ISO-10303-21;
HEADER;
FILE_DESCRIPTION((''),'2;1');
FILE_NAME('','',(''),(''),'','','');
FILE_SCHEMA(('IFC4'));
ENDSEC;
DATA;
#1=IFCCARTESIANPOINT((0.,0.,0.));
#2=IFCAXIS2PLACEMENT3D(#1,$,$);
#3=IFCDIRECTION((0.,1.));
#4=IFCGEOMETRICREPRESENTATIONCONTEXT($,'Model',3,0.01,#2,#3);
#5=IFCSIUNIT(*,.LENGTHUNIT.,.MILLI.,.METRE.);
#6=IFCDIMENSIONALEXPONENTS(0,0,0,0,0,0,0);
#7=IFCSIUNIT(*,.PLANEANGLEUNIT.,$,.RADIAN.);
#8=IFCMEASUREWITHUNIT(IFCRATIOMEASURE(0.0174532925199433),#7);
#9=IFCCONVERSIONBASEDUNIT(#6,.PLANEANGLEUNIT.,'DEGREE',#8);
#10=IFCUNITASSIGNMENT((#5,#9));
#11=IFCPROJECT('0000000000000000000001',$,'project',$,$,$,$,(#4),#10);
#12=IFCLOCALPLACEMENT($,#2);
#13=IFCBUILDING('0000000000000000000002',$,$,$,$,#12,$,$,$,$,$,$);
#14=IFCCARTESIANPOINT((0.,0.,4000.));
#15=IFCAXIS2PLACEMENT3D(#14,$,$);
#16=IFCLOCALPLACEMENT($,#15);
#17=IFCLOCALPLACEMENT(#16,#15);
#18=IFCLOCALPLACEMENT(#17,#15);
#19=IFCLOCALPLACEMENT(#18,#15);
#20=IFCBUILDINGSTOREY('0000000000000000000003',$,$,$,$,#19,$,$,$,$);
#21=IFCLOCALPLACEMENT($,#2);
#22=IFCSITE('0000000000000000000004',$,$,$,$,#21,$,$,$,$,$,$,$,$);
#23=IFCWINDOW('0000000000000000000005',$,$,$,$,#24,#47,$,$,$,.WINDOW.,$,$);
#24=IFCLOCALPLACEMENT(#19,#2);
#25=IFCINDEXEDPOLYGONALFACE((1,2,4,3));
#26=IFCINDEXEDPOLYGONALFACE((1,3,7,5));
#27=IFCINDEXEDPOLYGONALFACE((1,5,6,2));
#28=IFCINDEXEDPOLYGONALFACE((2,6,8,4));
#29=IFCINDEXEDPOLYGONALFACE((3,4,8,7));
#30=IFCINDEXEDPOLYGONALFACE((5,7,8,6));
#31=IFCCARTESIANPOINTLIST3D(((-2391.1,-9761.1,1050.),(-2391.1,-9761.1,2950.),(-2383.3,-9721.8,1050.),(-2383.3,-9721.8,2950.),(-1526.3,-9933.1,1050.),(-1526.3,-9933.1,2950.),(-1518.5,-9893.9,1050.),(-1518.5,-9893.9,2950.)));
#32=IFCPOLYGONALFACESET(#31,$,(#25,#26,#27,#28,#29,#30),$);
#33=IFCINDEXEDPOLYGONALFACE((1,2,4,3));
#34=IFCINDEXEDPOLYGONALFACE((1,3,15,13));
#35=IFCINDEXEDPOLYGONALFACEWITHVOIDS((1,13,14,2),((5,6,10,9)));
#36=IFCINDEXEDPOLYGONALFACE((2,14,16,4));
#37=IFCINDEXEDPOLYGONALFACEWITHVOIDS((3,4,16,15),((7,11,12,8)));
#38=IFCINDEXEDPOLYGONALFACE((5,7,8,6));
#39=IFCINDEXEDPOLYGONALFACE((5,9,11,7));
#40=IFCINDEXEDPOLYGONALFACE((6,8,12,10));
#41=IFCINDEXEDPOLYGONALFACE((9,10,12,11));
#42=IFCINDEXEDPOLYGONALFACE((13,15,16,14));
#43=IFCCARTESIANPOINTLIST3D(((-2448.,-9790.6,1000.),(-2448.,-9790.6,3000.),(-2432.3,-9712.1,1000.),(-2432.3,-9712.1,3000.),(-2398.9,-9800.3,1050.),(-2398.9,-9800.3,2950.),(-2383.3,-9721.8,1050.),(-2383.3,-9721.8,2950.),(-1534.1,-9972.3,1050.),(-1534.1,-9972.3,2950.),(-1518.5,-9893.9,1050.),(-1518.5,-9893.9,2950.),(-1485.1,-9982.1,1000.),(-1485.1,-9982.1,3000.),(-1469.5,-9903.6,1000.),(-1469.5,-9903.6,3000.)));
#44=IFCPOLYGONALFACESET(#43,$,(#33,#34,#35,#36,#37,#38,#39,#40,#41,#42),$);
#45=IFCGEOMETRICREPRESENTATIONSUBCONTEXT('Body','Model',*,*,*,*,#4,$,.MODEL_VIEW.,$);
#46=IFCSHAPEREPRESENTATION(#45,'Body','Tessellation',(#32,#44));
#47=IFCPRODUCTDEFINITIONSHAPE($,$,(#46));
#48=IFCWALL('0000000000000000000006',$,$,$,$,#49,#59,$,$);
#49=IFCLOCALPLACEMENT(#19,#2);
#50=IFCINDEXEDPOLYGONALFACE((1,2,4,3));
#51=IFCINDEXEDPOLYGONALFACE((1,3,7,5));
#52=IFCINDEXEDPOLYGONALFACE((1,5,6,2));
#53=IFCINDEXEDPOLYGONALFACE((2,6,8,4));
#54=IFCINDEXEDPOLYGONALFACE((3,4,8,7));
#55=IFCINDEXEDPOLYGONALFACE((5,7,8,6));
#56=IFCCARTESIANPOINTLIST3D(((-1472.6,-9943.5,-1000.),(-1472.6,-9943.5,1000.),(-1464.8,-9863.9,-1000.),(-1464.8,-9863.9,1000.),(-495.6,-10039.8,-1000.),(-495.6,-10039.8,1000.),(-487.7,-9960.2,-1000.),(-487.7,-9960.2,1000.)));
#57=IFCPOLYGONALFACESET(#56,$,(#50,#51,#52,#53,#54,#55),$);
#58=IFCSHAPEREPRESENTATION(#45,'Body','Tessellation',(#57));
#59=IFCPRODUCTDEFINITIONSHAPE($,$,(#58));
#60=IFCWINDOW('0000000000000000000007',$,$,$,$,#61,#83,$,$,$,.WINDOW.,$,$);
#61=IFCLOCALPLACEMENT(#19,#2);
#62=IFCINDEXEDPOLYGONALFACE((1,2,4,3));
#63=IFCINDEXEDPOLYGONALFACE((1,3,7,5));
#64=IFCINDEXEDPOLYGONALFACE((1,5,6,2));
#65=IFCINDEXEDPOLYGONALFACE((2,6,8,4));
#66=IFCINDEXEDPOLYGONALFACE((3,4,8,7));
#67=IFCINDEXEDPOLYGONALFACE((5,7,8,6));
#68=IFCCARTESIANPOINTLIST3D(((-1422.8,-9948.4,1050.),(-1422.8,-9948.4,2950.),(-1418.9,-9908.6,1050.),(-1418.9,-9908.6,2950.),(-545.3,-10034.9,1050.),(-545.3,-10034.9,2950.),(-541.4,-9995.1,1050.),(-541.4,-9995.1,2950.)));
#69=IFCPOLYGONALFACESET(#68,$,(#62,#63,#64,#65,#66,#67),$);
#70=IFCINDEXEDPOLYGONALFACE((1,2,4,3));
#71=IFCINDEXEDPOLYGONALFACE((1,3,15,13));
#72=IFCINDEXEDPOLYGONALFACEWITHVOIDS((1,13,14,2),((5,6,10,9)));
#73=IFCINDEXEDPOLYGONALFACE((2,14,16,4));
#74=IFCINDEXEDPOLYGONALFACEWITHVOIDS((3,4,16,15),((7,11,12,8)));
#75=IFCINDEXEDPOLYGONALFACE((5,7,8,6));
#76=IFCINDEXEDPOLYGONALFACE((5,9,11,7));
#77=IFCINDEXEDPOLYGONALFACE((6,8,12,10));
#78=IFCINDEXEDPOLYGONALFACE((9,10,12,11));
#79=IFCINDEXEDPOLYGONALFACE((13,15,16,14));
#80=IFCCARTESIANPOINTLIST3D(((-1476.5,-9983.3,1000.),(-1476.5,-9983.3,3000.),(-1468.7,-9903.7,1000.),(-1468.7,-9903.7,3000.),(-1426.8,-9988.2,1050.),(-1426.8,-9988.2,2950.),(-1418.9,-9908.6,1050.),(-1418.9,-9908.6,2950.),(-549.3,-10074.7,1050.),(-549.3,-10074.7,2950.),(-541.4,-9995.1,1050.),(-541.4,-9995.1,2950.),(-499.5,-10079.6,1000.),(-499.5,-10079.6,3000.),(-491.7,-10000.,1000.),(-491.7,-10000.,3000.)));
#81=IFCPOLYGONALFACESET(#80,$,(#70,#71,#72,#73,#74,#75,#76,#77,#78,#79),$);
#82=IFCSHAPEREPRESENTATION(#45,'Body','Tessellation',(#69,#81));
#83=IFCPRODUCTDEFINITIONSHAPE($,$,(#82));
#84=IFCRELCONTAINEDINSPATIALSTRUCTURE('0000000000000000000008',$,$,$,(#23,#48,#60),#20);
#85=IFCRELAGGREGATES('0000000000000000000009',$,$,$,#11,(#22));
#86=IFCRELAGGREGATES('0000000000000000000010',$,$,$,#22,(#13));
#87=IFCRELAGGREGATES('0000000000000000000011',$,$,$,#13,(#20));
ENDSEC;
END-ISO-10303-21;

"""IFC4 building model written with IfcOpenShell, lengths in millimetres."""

from ifc_helpers import new_model, entity, si_unit, converted_unit, direction, frame, origin, origin_2d, place, context, subcontext, project, spatial, rectangle, extrude, element, save


model = new_model("IFC4")

# Units and contexts
model_context = context("Model", 3, precision=0.01, world=origin(), true_north=direction((0.0, 1.0)))
body_context = subcontext(model_context, "Body", "Model", "MODEL_VIEW")
ifc_project = project(units=[si_unit("LENGTHUNIT", "METRE", prefix="MILLI"), converted_unit("PLANEANGLEUNIT", "DEGREE", entity("IfcRatioMeasure", 0.0174532925199433), si_unit("PLANEANGLEUNIT", "RADIAN"), dimensions=[0, 0, 0, 0, 0, 0, 0])], contexts=[model_context])

# Site, building, storey
site_placement = place(None, origin())
site = spatial("IfcSite", under=ifc_project, at=site_placement)
building_placement = place(None, origin())
building = spatial("IfcBuilding", under=site, at=building_placement)
placement_1 = place(None, frame((0.0, 0.0, 4000.0)))
placement_2 = place(placement_1, frame((0.0, 0.0, 4000.0)))
placement_3 = place(placement_2, frame((0.0, 0.0, 4000.0)))
storey_placement = place(placement_3, frame((0.0, 0.0, 4000.0)))
storey = spatial("IfcBuildingStorey", under=building, at=storey_placement)

# Shared definitions
cartesian_point_1 = entity("IfcCartesianPoint", [-440.9, -950.0])
shared_polyline = entity("IfcPolyline", [cartesian_point_1, entity("IfcCartesianPoint", [-440.9, 950.0]), entity("IfcCartesianPoint", [-440.9, 950.0]), entity("IfcCartesianPoint", [440.9, 950.0]), entity("IfcCartesianPoint", [440.9, 950.0]), entity("IfcCartesianPoint", [440.9, -950.0]), entity("IfcCartesianPoint", [440.9, -950.0]), entity("IfcCartesianPoint", [-440.9, -950.0]), cartesian_point_1])

# Window
window_1_placement = place(storey_placement, frame((-1950.9, -9807.9, 2000.0), z_axis=(0.0, 0.0, 1.0), x_axis=(9807.852671, -1950.903888, 0.0)))
cartesian_point_2 = entity("IfcCartesianPoint", [-490.9, -1000.0])
element("IfcWindow", 1, at=window_1_placement, inside=storey, PredefinedType="WINDOW", context=body_context, shape_type="SweptSolid", body=[
    entity("IfcExtrudedAreaSolid", entity("IfcArbitraryClosedProfileDef", "AREA", None, shared_polyline), entity("IfcAxis2Placement3D", entity("IfcCartesianPoint", [0.0, 0.0, 0.0]), entity("IfcDirection", [0.0, -1.0, 0.0]), entity("IfcDirection", [1.0, 0.0, 0.0])), entity("IfcDirection", [0.0, 0.0, 1.0]), 40.0),
    entity("IfcExtrudedAreaSolid", entity("IfcArbitraryProfileDefWithVoids", "AREA", None, entity("IfcPolyline", [cartesian_point_2, entity("IfcCartesianPoint", [-490.9, 1000.0]), entity("IfcCartesianPoint", [-490.9, 1000.0]), entity("IfcCartesianPoint", [490.9, 1000.0]), entity("IfcCartesianPoint", [490.9, 1000.0]), entity("IfcCartesianPoint", [490.9, -1000.0]), entity("IfcCartesianPoint", [490.9, -1000.0]), entity("IfcCartesianPoint", [-490.9, -1000.0]), cartesian_point_2]), [shared_polyline]), entity("IfcAxis2Placement3D", entity("IfcCartesianPoint", [0.0, 0.0, 0.0]), entity("IfcDirection", [0.0, -1.0, 0.0]), entity("IfcDirection", [1.0, 0.0, 0.0])), entity("IfcDirection", [0.0, 0.0, 1.0]), 80.0),
])

# Wall
wall_1_placement = place(storey_placement, frame((-980.2, -9951.8, -1000.0), z_axis=(0.0, 0.0, 1.0), x_axis=(9951.847473, -980.16931, 0.0)))
element("IfcWall", 2, at=wall_1_placement, inside=storey, context=body_context, shape_type="SweptSolid", body=[
    extrude(rectangle(XDim=981.7, YDim=80.0, at=origin_2d()), origin(), (0.0, 0.0, 1.0), 2000.0),
])

# Window
window_2_placement = place(storey_placement, frame((-980.2, -9951.8, 2000.0), z_axis=(0.0, 0.0, 1.0), x_axis=(9951.847473, -980.16931, 0.0)))
cartesian_point_3 = entity("IfcCartesianPoint", [-490.9, -1000.0])
element("IfcWindow", 3, at=window_2_placement, inside=storey, PredefinedType="WINDOW", context=body_context, shape_type="SweptSolid", body=[
    entity("IfcExtrudedAreaSolid", entity("IfcArbitraryClosedProfileDef", "AREA", None, shared_polyline), entity("IfcAxis2Placement3D", entity("IfcCartesianPoint", [0.0, 0.0, 0.0]), entity("IfcDirection", [0.0, -1.0, 0.0]), entity("IfcDirection", [1.0, 0.0, 0.0])), entity("IfcDirection", [0.0, 0.0, 1.0]), 40.0),
    entity("IfcExtrudedAreaSolid", entity("IfcArbitraryProfileDefWithVoids", "AREA", None, entity("IfcPolyline", [cartesian_point_3, entity("IfcCartesianPoint", [-490.9, 1000.0]), entity("IfcCartesianPoint", [-490.9, 1000.0]), entity("IfcCartesianPoint", [490.9, 1000.0]), entity("IfcCartesianPoint", [490.9, 1000.0]), entity("IfcCartesianPoint", [490.9, -1000.0]), entity("IfcCartesianPoint", [490.9, -1000.0]), entity("IfcCartesianPoint", [-490.9, -1000.0]), cartesian_point_3]), [shared_polyline]), entity("IfcAxis2Placement3D", entity("IfcCartesianPoint", [0.0, 0.0, 0.0]), entity("IfcDirection", [0.0, -1.0, 0.0]), entity("IfcDirection", [1.0, 0.0, 0.0])), entity("IfcDirection", [0.0, 0.0, 1.0]), 80.0),
])

save(model, "model.ifc")
